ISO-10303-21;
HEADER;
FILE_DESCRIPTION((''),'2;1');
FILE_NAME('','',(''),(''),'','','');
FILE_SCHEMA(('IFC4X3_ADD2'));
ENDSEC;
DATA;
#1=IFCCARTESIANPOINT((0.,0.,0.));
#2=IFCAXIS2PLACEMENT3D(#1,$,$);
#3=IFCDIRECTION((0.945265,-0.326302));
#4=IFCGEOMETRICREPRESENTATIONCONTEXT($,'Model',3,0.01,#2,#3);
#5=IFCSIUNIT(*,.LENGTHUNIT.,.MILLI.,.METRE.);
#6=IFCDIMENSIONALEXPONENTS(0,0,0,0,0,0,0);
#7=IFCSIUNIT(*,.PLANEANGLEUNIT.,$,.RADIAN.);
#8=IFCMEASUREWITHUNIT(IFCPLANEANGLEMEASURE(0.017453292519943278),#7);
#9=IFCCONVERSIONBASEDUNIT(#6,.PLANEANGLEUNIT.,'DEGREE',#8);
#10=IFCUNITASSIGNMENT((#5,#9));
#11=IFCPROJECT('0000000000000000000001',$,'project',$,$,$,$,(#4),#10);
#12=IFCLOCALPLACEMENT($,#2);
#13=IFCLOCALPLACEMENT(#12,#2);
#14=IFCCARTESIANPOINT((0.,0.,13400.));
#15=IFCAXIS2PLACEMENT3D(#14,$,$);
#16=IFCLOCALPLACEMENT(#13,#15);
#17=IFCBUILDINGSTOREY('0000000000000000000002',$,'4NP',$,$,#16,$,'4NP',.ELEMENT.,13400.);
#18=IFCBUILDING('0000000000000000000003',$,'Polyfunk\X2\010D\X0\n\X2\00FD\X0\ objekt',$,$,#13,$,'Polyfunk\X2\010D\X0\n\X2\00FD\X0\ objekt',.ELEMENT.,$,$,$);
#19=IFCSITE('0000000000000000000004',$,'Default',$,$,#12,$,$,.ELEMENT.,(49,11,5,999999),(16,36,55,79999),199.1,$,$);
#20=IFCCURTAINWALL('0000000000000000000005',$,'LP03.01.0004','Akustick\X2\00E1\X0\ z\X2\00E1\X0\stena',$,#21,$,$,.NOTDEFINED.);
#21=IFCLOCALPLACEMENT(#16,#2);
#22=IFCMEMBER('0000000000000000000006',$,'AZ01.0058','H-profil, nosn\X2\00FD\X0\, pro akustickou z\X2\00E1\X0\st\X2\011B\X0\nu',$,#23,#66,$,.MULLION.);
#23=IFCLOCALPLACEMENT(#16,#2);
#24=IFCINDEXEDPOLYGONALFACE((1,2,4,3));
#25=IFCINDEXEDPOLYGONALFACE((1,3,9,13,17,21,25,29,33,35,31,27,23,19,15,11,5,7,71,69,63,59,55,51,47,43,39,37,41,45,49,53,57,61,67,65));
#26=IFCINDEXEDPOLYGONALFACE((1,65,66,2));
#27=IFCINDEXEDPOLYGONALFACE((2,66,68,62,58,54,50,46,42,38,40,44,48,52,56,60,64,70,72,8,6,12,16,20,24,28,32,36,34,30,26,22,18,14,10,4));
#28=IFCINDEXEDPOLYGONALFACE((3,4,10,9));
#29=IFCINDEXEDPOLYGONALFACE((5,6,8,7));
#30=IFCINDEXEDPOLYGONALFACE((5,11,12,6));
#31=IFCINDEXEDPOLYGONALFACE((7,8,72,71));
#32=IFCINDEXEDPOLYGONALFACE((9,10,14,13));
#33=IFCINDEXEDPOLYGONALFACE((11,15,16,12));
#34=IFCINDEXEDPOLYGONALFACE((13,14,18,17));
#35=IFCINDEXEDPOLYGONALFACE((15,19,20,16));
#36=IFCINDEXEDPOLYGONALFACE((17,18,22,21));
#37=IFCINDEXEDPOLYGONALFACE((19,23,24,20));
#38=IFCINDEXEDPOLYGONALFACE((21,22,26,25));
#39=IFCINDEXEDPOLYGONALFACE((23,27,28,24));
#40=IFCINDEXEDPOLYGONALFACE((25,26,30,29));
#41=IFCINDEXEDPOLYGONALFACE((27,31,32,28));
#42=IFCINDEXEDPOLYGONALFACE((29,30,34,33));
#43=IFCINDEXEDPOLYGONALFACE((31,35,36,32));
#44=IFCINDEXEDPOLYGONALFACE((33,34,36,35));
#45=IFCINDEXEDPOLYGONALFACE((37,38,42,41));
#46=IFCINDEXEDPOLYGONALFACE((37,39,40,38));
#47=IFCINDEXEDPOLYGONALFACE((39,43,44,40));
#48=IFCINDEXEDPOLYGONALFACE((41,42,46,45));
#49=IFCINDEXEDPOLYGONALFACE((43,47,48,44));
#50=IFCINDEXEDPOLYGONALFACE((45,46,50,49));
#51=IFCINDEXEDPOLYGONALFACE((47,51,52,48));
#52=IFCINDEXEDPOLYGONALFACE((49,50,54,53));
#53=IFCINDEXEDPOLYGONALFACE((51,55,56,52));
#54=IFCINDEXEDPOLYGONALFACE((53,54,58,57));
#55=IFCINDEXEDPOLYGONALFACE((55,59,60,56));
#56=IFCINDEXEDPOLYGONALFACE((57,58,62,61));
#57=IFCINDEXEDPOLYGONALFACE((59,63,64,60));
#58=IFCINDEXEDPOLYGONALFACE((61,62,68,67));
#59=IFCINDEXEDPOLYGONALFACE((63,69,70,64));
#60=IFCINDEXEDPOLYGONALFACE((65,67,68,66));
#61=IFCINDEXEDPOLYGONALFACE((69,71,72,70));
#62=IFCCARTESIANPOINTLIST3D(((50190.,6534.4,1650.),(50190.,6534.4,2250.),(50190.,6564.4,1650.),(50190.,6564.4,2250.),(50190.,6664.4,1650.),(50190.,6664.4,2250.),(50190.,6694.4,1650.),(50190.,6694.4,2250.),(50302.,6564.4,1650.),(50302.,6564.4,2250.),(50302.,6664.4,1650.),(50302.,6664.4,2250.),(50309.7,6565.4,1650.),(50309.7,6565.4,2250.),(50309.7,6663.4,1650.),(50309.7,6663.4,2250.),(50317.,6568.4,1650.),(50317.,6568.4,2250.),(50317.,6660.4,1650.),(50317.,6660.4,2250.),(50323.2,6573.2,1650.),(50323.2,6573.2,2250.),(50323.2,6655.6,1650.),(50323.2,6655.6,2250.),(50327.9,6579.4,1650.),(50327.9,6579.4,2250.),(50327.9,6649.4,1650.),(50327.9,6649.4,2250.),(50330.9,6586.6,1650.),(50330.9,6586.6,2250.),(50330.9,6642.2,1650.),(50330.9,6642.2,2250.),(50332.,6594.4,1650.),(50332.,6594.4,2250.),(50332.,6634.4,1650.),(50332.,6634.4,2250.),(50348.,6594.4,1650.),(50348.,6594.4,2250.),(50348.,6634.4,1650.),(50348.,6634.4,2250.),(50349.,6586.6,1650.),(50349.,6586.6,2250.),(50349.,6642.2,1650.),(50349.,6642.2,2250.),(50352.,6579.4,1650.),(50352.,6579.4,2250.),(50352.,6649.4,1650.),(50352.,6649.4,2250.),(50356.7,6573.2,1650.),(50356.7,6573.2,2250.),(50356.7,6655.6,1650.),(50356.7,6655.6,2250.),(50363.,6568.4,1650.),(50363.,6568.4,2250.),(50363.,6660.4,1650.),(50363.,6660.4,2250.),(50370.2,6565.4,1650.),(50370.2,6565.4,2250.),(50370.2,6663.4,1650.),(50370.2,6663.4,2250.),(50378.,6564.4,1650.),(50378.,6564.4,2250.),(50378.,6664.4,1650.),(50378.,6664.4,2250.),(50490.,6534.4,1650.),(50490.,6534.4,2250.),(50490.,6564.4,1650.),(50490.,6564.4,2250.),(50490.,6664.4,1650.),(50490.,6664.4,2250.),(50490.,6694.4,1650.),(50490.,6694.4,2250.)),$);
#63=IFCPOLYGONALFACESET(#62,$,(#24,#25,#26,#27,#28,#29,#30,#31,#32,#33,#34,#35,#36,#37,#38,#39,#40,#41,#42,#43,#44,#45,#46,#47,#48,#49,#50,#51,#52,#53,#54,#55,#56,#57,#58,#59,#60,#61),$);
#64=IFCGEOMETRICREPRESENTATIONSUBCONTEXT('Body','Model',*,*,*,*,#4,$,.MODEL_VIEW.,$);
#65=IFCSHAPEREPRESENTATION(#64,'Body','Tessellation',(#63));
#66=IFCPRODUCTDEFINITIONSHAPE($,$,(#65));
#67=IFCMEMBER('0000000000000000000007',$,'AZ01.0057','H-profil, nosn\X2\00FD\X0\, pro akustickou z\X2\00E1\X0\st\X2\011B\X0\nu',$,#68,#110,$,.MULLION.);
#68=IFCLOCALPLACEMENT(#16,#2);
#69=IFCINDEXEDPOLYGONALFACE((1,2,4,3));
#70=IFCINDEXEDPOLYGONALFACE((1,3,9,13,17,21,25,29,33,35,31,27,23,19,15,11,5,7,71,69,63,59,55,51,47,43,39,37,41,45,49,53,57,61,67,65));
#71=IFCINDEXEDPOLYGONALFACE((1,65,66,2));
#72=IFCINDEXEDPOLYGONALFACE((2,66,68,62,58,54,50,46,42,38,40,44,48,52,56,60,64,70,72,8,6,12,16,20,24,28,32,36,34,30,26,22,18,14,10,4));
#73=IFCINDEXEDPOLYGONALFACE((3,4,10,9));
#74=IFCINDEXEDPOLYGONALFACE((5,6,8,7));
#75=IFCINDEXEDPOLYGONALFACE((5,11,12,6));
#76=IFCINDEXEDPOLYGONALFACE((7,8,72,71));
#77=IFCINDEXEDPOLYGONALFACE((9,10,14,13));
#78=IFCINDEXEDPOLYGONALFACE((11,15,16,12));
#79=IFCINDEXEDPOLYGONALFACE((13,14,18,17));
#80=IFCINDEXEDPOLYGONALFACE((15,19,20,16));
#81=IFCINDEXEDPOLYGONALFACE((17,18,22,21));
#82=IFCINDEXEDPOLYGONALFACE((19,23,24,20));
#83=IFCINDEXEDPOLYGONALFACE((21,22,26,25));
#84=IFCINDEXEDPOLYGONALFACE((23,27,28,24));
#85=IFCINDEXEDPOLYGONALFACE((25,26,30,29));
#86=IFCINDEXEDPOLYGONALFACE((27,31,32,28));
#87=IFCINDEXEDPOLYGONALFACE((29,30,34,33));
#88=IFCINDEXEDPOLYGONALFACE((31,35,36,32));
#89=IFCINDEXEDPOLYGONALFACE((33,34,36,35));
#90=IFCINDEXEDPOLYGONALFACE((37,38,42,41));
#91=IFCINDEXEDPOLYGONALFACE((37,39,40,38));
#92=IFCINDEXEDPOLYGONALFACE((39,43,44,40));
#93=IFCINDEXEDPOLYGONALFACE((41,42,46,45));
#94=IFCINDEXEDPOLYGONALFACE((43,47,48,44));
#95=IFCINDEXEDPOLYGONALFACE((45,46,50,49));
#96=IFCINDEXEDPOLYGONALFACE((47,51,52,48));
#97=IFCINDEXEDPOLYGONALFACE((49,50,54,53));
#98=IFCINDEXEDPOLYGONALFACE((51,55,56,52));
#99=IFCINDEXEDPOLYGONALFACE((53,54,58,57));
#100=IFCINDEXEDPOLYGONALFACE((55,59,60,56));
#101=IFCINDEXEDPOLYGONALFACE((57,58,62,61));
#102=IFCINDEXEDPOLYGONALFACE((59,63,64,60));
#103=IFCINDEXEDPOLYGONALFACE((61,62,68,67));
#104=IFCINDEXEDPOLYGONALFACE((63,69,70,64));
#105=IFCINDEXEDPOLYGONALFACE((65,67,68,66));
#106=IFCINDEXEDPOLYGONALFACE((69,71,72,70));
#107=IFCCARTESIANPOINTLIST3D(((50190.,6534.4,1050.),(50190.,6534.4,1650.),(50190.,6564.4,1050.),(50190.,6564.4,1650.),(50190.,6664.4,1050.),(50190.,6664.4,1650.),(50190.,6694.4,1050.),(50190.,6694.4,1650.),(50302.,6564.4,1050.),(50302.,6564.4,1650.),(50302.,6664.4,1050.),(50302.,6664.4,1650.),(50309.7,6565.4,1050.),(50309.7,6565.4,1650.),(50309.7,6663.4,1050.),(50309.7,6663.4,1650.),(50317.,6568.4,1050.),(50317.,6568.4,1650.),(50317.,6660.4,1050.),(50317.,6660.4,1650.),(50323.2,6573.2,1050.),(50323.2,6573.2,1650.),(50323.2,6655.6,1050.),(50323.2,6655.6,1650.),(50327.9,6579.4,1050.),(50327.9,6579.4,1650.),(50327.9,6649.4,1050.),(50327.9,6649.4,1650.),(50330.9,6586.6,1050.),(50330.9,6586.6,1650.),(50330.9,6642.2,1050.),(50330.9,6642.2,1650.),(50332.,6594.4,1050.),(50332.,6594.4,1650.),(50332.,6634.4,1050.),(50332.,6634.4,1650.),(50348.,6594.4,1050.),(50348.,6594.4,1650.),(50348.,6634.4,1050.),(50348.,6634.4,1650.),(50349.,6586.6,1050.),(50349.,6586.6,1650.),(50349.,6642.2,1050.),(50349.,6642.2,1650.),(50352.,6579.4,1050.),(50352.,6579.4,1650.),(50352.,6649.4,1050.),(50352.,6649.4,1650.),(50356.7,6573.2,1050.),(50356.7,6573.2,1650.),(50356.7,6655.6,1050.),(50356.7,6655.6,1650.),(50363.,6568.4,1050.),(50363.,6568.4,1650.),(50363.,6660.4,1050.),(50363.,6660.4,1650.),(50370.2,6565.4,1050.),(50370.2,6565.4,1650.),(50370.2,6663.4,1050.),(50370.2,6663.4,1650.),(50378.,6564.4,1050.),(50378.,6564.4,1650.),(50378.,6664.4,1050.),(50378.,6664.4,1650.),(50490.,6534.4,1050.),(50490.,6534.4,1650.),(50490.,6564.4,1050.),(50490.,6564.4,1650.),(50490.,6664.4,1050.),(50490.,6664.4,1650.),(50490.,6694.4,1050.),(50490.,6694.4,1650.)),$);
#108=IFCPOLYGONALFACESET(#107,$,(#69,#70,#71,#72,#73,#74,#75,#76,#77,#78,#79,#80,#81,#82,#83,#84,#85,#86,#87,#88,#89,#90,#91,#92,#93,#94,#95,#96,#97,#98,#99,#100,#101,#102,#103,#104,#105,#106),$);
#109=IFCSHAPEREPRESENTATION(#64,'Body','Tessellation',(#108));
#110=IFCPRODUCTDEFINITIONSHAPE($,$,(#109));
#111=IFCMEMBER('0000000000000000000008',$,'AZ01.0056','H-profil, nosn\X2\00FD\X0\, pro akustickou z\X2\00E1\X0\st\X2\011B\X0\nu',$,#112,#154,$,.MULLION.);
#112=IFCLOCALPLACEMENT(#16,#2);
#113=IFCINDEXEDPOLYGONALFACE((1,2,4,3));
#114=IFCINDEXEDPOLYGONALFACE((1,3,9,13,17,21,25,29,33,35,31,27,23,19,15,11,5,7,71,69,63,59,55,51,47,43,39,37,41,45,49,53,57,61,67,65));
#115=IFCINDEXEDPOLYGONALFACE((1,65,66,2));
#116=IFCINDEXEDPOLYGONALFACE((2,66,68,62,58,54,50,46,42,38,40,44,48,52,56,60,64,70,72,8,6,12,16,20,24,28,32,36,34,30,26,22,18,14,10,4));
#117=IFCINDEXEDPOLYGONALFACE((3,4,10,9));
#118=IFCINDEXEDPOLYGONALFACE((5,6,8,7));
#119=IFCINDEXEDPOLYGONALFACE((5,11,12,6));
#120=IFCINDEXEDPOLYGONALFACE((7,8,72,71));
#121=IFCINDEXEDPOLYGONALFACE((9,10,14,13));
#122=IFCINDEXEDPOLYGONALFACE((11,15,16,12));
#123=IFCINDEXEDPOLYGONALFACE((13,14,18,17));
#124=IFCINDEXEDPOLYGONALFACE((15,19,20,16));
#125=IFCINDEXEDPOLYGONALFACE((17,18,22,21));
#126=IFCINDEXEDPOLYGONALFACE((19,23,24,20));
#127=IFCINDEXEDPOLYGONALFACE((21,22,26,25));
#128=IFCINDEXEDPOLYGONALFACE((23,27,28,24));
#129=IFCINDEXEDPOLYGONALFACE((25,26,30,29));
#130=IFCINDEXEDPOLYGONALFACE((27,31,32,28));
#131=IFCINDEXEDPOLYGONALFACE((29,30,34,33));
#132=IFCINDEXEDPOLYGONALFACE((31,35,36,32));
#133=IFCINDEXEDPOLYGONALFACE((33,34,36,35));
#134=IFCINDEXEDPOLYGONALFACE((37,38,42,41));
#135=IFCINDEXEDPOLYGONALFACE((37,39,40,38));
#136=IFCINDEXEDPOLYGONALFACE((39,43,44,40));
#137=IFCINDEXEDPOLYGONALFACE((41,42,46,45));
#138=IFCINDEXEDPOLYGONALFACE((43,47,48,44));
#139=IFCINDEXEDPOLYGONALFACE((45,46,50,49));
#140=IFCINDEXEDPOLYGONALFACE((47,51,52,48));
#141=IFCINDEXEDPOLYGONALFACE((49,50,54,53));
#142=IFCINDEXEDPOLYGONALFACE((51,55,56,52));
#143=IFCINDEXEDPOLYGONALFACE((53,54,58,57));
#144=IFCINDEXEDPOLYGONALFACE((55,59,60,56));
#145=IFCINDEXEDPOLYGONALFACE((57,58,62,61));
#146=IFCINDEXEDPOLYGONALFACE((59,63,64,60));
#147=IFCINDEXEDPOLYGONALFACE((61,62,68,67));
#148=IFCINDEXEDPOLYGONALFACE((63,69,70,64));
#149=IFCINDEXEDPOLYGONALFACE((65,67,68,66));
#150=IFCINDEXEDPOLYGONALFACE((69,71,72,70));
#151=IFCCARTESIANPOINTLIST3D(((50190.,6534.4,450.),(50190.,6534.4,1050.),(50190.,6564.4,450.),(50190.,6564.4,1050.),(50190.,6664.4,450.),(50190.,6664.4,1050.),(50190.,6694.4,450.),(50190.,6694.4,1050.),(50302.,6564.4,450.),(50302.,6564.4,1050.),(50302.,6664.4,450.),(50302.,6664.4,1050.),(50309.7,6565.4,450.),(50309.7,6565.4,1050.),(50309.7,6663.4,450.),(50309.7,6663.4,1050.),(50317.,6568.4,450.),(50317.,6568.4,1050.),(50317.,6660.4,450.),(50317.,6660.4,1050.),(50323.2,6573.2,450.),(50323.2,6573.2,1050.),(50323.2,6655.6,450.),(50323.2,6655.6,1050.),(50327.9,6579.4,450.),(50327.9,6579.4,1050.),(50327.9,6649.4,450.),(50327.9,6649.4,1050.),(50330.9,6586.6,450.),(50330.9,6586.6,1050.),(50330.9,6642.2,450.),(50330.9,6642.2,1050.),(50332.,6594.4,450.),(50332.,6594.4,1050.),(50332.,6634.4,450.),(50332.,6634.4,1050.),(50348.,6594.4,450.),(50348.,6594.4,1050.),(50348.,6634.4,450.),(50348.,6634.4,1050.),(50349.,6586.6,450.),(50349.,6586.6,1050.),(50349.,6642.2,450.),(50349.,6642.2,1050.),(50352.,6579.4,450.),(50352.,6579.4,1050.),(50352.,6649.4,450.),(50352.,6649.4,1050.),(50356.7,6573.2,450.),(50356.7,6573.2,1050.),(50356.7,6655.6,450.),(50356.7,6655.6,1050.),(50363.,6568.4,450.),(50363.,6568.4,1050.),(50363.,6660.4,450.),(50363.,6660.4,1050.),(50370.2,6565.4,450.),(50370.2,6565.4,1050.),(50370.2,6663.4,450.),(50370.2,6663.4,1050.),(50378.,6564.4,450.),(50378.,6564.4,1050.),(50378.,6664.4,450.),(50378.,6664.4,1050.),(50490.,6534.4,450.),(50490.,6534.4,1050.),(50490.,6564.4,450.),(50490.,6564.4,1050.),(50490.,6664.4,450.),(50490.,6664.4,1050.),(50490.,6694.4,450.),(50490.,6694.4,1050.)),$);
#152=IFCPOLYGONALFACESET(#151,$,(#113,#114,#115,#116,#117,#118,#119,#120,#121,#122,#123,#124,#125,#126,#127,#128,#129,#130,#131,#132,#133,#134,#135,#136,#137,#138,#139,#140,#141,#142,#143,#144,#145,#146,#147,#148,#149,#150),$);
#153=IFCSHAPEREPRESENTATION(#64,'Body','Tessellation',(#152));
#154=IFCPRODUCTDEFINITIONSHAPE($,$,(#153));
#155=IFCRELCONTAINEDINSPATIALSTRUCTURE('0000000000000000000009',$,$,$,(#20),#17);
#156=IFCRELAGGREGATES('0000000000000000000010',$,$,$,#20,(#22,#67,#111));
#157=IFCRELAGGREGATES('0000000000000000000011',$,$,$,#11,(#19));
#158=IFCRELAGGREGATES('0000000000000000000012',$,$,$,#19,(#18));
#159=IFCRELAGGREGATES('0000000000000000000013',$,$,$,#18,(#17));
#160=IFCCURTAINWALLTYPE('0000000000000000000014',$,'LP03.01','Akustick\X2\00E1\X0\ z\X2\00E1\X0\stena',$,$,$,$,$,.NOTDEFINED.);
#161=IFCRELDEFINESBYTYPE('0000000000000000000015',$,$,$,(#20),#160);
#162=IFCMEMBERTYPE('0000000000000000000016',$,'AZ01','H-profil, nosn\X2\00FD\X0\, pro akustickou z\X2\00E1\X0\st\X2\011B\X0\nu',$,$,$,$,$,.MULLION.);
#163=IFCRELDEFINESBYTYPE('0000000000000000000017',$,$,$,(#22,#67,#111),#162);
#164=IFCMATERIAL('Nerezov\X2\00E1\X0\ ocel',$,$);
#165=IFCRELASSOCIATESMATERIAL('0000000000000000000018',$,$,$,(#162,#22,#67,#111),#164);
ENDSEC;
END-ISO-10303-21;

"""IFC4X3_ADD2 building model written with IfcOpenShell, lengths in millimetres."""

from ifc_helpers import new_model, entity, si_unit, converted_unit, direction, frame, frame_2d, origin, place, context, subcontext, project, spatial, polyline, circle_curve, parameter, trimmed, segment, composite_curve, outline, extrude, source, transform, mapped, material, material_profile, profile_set, profile_usage, type_object, element, aggregate, save


model = new_model("IFC4X3_ADD2")

# Units and contexts
model_context = context("Model", 3, precision=0.01, world=origin(), true_north=direction((0.945265, -0.326302)))
body_context = subcontext(model_context, "Body", "Model", "MODEL_VIEW")
ifc_project = project(units=[si_unit("LENGTHUNIT", "METRE", prefix="MILLI"), converted_unit("PLANEANGLEUNIT", "DEGREE", entity("IfcPlaneAngleMeasure", 0.017453292519943278), si_unit("PLANEANGLEUNIT", "RADIAN"), dimensions=[0, 0, 0, 0, 0, 0, 0])], contexts=[model_context])

# Site, building, storey
site_placement = place(None, origin())
site = spatial("IfcSite", under=ifc_project, at=site_placement, Name="Default", CompositionType="ELEMENT", RefLatitude=(49, 11, 5, 999999), RefLongitude=(16, 36, 55, 79999), RefElevation=199.1)
building_placement = place(site_placement, origin())
building = spatial("IfcBuilding", under=site, at=building_placement, Name="Polyfunkčný objekt", LongName="Polyfunkčný objekt", CompositionType="ELEMENT")
storey_placement = place(building_placement, frame((0.0, 0.0, 13400.0)))
storey = spatial("IfcBuildingStorey", under=building, at=storey_placement, Name="4NP", LongName="4NP", CompositionType="ELEMENT", Elevation=13400.0)

# Curtain wall, members
curtain_wall_type = type_object("IfcCurtainWallType", Name="LP03.01", Description="Akustická zástena", PredefinedType="NOTDEFINED")
curtain_wall_1_placement = place(storey_placement, frame((0.0, 0.0, -13400.0)))
curtain_wall_1 = element("IfcCurtainWall", 1, at=curtain_wall_1_placement, inside=storey, type_object=curtain_wall_type, Name="LP03.01.0004", Description="Akustická zástena", PredefinedType="NOTDEFINED")
ifc_material_1 = material(Name="Nerezová ocel")
ifc_material_profile = material_profile(ifc_material_1, outline(composite_curve([segment(polyline([(50.0, -150.0), (80.0, -150.0)]), True, "CONTINUOUS"), segment(polyline([(80.0, -150.0), (80.0, 150.0)]), True, "CONTINUOUS"), segment(polyline([(80.0, 150.0), (50.0, 150.0)]), True, "CONTINUOUS"), segment(polyline([(50.0, 150.0), (50.0, 38.0)]), True, "CONTINUOUS"), segment(trimmed(circle_curve(frame_2d((20.0, 38.0), x_axis=(0.0, 1.0)), 30.0), [parameter(180.0)], [parameter(270.0)], True, "PARAMETER"), False, "CONTINUOUS"), segment(polyline([(20.0, 8.0), (-20.0, 8.0)]), True, "CONTINUOUS"), segment(trimmed(circle_curve(frame_2d((-20.0, 38.0), x_axis=(0.0, 1.0)), 30.0), [parameter(90.0)], [parameter(180.0)], True, "PARAMETER"), False, "CONTINUOUS"), segment(polyline([(-50.0, 38.0), (-50.0, 150.0)]), True, "CONTINUOUS"), segment(polyline([(-50.0, 150.0), (-80.0, 150.0)]), True, "CONTINUOUS"), segment(polyline([(-80.0, 150.0), (-80.0, -150.0)]), True, "CONTINUOUS"), segment(polyline([(-80.0, -150.0), (-50.0, -150.0)]), True, "CONTINUOUS"), segment(polyline([(-50.0, -150.0), (-50.0, -38.0)]), True, "CONTINUOUS"), segment(trimmed(circle_curve(frame_2d((-20.0, -38.0), x_axis=(0.0, 1.0)), 30.0), [parameter(0.0)], [parameter(90.0)], True, "PARAMETER"), False, "CONTINUOUS"), segment(polyline([(-20.0, -8.0), (20.0, -8.0)]), True, "CONTINUOUS"), segment(trimmed(circle_curve(frame_2d((20.0, -38.0), x_axis=(0.0, 1.0)), 30.0), [parameter(270.0)], [parameter(0.0)], True, "PARAMETER"), False, "CONTINUOUS"), segment(polyline([(50.0, -38.0), (50.0, -150.0)]), True, "CONTINUOUS")], self_intersect=False)), Name="Profil zástena")
ifc_profile_set = profile_set([ifc_material_profile], Name="Profil zástena")
ifc_profile_usage = profile_usage(ifc_profile_set)
member_type = type_object("IfcMemberType", Name="AZ01", Description="H-profil, nosný, pro akustickou zástěnu", PredefinedType="MULLION", material=ifc_profile_set)
shared_shape_1 = source(origin(), body_context, "Body", "SweptSolid", [
    extrude(outline(composite_curve([segment(polyline([(-150.0, -50.0), (-150.0, -80.0)]), True, "CONTINUOUS"), segment(polyline([(-150.0, -80.0), (150.0, -80.0)]), True, "CONTINUOUS"), segment(polyline([(150.0, -80.0), (150.0, -50.0)]), True, "CONTINUOUS"), segment(polyline([(150.0, -50.0), (38.0, -50.0)]), True, "CONTINUOUS"), segment(trimmed(circle_curve(frame_2d((38.0, -20.0), x_axis=(1.0, 0.0)), 30.0), [parameter(180.0)], [parameter(270.0)], True, "PARAMETER"), False, "CONTINUOUS"), segment(polyline([(8.0, -20.0), (8.0, 20.0)]), True, "CONTINUOUS"), segment(trimmed(circle_curve(frame_2d((38.0, 20.0), x_axis=(1.0, 0.0)), 30.0), [parameter(90.0)], [parameter(180.0)], True, "PARAMETER"), False, "CONTINUOUS"), segment(polyline([(38.0, 50.0), (150.0, 50.0)]), True, "CONTINUOUS"), segment(polyline([(150.0, 50.0), (150.0, 80.0)]), True, "CONTINUOUS"), segment(polyline([(150.0, 80.0), (-150.0, 80.0)]), True, "CONTINUOUS"), segment(polyline([(-150.0, 80.0), (-150.0, 50.0)]), True, "CONTINUOUS"), segment(polyline([(-150.0, 50.0), (-38.0, 50.0)]), True, "CONTINUOUS"), segment(trimmed(circle_curve(frame_2d((-38.0, 20.0), x_axis=(1.0, 0.0)), 30.0), [parameter(0.0)], [parameter(90.0)], True, "PARAMETER"), False, "CONTINUOUS"), segment(polyline([(-8.0, 20.0), (-8.0, -20.0)]), True, "CONTINUOUS"), segment(trimmed(circle_curve(frame_2d((-38.0, -20.0), x_axis=(1.0, 0.0)), 30.0), [parameter(270.0)], [parameter(0.0)], True, "PARAMETER"), False, "CONTINUOUS"), segment(polyline([(-38.0, -50.0), (-150.0, -50.0)]), True, "CONTINUOUS")], self_intersect=False)), frame((-150.0, 0.0, -600.0), z_axis=(0.0, 0.0, -1.0), x_axis=(-1.0, 0.0, 0.0)), (0.0, 0.0, -1.0), 600.0),
])
member_1_placement = place(curtain_wall_1_placement, frame((50190.0, 6614.4, 15650.0), z_axis=(0.0, 0.0, 1.0), x_axis=(-1.0, 0.0, 0.0)))
member_1 = element("IfcMember", 2, at=member_1_placement, type_object=member_type, material=ifc_profile_usage, Name="AZ01.0058", Description="H-profil, nosný, pro akustickou zástěnu", PredefinedType="MULLION", context=body_context, shape_type="MappedRepresentation", body=[
    mapped(shared_shape_1, transform((0.0, 0.0, 0.0), scale=1.0)),
])
member_2_placement = place(curtain_wall_1_placement, frame((50190.0, 6614.4, 15050.0), z_axis=(0.0, 0.0, 1.0), x_axis=(-1.0, 0.0, 0.0)))
member_2 = element("IfcMember", 3, at=member_2_placement, type_object=member_type, material=ifc_profile_usage, Name="AZ01.0057", Description="H-profil, nosný, pro akustickou zástěnu", PredefinedType="MULLION", context=body_context, shape_type="MappedRepresentation", body=[
    mapped(shared_shape_1, transform((0.0, 0.0, 0.0), scale=1.0)),
])
member_3_placement = place(curtain_wall_1_placement, frame((50190.0, 6614.4, 14450.0), z_axis=(0.0, 0.0, 1.0), x_axis=(-1.0, 0.0, 0.0)))
member_3 = element("IfcMember", 4, at=member_3_placement, type_object=member_type, material=ifc_profile_usage, Name="AZ01.0056", Description="H-profil, nosný, pro akustickou zástěnu", PredefinedType="MULLION", context=body_context, shape_type="MappedRepresentation", body=[
    mapped(shared_shape_1, transform((0.0, 0.0, 0.0), scale=1.0)),
])

aggregate(curtain_wall_1, [member_1, member_2, member_3])

save(model, "model.ifc")
